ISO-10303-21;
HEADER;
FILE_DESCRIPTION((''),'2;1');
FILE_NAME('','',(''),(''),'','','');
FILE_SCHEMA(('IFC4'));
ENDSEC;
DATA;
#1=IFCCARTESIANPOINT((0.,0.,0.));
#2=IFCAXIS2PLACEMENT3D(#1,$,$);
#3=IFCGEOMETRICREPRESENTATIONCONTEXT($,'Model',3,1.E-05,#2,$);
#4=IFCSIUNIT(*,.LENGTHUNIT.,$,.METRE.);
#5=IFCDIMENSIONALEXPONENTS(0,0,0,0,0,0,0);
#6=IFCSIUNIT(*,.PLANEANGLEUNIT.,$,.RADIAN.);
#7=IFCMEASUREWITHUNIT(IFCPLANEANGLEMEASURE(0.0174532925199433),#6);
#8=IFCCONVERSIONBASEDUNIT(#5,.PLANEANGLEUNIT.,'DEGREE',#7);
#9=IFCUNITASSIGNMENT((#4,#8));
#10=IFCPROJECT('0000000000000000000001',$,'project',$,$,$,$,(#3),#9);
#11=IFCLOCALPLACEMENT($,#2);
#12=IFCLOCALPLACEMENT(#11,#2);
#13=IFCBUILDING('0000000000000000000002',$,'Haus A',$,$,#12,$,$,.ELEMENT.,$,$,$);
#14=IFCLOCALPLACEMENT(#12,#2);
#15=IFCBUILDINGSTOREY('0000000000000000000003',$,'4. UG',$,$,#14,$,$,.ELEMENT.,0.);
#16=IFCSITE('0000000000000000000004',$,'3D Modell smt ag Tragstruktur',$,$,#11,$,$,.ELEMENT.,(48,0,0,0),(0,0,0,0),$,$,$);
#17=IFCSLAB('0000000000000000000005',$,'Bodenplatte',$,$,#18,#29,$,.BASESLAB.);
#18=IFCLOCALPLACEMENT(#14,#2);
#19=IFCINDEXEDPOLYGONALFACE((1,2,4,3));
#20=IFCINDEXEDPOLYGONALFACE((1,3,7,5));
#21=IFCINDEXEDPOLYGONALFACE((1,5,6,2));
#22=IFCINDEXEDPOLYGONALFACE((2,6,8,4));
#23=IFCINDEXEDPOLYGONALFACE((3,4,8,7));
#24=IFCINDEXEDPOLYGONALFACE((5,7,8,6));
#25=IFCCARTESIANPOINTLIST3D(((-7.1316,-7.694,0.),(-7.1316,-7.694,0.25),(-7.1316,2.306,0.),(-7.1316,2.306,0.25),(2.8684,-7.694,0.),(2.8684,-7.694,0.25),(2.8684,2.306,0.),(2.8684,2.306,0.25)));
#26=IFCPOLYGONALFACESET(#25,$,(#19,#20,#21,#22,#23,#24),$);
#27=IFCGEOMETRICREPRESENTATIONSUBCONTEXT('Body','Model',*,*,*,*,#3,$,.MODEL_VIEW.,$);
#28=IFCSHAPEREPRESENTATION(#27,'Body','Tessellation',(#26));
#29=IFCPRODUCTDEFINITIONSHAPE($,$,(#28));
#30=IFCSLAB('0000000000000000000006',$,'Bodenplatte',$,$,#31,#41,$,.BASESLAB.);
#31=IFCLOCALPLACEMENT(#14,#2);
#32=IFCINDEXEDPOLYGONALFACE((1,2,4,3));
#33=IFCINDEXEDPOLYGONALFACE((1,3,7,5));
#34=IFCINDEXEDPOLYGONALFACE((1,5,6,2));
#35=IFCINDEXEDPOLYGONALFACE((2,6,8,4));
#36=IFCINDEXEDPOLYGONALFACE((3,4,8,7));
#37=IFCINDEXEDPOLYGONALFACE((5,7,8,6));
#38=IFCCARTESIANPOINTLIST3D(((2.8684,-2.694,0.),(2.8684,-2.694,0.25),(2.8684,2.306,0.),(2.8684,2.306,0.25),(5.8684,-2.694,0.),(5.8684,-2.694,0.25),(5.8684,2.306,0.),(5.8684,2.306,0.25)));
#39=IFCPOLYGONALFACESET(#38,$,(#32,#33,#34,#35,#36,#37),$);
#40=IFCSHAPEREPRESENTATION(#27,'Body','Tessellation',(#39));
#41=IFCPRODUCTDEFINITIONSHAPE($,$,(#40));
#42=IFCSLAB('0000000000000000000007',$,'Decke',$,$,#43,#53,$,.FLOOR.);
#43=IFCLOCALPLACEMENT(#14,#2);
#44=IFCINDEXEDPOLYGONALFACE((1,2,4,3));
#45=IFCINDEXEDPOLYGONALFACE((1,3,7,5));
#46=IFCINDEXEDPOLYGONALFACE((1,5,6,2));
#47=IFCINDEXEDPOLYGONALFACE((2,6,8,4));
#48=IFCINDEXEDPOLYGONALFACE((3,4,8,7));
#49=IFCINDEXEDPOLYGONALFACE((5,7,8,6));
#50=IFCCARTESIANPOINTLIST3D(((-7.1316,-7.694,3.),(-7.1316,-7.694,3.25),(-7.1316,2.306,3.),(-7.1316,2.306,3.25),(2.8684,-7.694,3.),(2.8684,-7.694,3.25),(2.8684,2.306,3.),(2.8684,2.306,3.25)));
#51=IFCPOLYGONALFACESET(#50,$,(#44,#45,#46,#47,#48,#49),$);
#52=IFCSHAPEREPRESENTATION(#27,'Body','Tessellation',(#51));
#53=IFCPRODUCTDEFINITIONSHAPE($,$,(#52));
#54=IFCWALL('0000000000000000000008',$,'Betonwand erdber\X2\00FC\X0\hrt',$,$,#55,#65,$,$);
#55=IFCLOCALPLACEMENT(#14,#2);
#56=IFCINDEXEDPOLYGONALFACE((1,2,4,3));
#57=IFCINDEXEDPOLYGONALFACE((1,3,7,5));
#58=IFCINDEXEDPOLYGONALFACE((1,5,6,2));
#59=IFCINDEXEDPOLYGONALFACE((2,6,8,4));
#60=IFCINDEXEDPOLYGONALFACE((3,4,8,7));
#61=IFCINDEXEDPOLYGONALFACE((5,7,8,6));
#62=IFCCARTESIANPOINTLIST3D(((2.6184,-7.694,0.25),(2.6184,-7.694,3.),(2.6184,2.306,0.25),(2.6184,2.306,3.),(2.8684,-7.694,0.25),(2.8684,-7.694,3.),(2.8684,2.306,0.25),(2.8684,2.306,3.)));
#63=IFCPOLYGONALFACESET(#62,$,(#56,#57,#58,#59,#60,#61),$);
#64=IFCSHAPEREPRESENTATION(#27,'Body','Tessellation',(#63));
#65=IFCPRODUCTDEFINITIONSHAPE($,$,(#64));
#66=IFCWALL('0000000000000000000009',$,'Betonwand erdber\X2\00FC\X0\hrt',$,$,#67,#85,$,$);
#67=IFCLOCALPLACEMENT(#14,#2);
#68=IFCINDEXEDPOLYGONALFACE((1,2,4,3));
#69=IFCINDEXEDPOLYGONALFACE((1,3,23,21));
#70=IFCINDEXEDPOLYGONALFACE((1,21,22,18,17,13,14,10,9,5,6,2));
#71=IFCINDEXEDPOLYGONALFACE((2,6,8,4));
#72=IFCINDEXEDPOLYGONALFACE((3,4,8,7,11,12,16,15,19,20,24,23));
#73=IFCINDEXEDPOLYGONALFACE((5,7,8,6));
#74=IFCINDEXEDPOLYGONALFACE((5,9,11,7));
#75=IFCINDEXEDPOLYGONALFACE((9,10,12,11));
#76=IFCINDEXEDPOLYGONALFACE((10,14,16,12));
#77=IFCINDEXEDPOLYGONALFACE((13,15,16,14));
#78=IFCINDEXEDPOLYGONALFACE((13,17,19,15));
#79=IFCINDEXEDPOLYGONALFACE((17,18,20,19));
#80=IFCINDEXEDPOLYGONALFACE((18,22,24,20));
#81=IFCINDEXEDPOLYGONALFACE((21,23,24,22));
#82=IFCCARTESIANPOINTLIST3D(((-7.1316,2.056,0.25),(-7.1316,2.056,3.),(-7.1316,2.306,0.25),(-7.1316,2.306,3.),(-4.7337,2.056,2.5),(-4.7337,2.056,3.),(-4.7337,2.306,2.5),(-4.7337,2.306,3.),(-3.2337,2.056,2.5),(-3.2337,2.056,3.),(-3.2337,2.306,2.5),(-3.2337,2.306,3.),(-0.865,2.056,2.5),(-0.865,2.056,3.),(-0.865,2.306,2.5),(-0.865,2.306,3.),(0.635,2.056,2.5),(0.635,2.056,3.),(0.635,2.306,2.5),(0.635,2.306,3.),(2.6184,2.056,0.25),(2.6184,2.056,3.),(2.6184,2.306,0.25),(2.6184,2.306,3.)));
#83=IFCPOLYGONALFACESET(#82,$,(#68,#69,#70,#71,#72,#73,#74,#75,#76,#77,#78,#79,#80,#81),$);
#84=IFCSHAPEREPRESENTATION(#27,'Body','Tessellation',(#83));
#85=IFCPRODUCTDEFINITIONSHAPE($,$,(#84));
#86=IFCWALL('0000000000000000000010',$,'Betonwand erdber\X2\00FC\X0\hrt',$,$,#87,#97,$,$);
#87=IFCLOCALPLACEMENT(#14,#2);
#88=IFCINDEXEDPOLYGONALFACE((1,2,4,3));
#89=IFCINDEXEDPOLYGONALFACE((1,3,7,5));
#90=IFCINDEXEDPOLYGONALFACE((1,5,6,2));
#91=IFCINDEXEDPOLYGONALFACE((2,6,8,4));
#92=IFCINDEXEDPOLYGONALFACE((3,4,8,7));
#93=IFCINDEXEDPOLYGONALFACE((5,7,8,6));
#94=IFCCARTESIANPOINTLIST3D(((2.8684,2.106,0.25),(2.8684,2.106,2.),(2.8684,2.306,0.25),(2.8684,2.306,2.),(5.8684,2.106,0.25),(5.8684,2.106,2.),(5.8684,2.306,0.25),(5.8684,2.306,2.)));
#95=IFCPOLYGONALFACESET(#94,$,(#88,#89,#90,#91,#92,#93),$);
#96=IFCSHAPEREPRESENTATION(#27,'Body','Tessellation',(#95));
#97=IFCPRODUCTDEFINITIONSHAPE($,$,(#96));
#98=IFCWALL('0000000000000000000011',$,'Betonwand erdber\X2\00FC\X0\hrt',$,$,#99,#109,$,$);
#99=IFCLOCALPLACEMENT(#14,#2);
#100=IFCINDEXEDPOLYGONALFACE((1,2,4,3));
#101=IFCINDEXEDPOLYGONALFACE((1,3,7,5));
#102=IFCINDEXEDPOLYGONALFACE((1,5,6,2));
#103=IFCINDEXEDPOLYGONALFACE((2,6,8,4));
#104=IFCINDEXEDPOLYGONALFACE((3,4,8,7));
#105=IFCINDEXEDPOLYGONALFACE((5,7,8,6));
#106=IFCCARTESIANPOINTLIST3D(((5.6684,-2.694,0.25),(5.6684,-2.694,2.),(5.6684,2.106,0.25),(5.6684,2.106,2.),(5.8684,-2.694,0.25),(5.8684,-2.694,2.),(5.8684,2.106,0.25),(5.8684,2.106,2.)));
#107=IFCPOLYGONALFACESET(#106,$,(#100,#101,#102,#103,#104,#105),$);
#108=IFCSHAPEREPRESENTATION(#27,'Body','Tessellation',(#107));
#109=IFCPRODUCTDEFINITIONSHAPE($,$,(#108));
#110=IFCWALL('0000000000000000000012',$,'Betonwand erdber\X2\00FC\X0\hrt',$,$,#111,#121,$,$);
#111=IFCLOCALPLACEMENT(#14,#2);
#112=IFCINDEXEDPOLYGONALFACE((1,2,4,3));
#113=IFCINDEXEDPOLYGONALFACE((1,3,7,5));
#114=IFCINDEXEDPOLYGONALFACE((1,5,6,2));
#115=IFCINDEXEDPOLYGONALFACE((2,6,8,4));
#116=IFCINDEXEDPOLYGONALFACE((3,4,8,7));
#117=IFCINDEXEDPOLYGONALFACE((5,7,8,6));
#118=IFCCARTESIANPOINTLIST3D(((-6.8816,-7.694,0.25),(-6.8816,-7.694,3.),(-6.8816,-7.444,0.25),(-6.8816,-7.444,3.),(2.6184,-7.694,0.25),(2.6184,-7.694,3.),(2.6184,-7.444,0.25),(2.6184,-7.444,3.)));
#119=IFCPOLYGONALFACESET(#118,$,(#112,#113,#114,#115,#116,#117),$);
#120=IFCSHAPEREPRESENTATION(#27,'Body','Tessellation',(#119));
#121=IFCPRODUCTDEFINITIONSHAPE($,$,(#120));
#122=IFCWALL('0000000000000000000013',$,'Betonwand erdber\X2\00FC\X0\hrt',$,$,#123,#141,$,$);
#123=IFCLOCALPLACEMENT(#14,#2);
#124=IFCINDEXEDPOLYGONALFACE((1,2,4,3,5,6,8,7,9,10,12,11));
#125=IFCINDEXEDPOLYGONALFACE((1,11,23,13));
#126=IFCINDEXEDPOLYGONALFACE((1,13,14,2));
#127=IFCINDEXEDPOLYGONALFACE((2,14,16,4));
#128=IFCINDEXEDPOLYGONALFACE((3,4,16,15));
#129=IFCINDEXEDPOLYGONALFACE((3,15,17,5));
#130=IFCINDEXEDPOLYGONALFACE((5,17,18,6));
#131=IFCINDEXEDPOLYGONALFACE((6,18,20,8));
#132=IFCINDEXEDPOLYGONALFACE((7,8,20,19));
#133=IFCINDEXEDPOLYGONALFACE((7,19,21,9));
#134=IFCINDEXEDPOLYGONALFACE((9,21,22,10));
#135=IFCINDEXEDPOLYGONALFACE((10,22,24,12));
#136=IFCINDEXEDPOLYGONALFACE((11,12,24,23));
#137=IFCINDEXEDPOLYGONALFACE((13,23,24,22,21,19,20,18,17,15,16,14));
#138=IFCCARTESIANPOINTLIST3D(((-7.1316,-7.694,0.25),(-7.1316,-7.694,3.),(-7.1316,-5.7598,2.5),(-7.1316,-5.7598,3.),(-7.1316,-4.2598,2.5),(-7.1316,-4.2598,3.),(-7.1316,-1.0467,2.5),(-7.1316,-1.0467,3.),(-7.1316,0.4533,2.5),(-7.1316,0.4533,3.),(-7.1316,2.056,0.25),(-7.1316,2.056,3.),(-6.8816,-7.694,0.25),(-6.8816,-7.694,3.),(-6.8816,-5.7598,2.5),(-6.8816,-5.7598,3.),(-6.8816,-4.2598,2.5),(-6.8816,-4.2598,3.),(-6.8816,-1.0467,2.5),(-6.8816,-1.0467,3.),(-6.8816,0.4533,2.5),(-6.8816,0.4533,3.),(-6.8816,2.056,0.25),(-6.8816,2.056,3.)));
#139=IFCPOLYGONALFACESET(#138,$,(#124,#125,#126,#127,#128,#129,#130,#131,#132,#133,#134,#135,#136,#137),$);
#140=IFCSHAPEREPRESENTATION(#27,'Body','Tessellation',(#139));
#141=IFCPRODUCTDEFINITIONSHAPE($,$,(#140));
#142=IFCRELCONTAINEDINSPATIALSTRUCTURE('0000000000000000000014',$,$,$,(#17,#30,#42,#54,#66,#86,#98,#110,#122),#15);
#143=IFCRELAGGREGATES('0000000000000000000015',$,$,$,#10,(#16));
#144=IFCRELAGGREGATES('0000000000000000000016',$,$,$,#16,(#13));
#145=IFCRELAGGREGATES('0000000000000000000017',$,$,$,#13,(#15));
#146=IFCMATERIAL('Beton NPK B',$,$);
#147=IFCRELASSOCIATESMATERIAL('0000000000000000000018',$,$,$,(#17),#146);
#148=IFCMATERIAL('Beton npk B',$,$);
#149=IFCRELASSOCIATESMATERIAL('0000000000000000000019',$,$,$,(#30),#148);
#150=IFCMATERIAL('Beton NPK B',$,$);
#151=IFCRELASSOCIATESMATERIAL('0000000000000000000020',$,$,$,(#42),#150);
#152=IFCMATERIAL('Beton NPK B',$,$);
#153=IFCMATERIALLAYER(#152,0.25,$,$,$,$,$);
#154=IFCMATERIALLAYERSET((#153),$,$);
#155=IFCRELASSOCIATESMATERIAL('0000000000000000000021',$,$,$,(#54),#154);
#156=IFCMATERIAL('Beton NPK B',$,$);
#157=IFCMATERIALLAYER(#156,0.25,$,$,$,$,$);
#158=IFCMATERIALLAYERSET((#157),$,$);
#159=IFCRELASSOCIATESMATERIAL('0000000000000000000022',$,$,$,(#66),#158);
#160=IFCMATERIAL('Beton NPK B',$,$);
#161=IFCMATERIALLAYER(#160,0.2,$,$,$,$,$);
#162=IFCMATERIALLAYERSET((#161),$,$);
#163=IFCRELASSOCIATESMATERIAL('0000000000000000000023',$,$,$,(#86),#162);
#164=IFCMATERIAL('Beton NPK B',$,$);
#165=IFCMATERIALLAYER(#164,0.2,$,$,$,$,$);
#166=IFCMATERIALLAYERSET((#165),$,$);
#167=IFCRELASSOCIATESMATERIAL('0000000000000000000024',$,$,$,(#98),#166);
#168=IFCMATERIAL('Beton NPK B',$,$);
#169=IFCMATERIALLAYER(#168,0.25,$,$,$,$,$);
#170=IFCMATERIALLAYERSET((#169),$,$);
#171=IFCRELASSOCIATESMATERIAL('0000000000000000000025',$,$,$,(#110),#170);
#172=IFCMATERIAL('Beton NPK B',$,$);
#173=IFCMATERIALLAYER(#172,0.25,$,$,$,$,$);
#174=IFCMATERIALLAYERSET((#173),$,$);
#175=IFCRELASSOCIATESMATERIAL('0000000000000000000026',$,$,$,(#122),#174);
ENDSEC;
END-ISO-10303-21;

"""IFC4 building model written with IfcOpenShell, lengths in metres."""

from ifc_helpers import new_model, entity, si_unit, converted_unit, frame, frame_2d, origin, origin_with_axes, place, context, subcontext, project, spatial, polyline, rectangle, outline, extrude, material, layer, layer_set, layer_usage, element, save


model = new_model("IFC4")

# Units and contexts
model_context = context("Model", 3, precision=1e-05, world=origin())
body_context = subcontext(model_context, "Body", "Model", "MODEL_VIEW")
ifc_project = project(units=[si_unit("LENGTHUNIT", "METRE"), converted_unit("PLANEANGLEUNIT", "DEGREE", entity("IfcPlaneAngleMeasure", 0.0174532925199433), si_unit("PLANEANGLEUNIT", "RADIAN"), dimensions=[0, 0, 0, 0, 0, 0, 0])], contexts=[model_context])

# Site, building, storey
site_placement = place(None, origin())
site = spatial("IfcSite", under=ifc_project, at=site_placement, Name="3D Modell smt ag Tragstruktur", CompositionType="ELEMENT", RefLatitude=(48, 0, 0, 0), RefLongitude=(0, 0, 0, 0))
building_placement = place(site_placement, origin())
building = spatial("IfcBuilding", under=site, at=building_placement, Name="Haus A", CompositionType="ELEMENT")
storey_placement = place(building_placement, origin())
storey = spatial("IfcBuildingStorey", under=building, at=storey_placement, Name="4. UG", CompositionType="ELEMENT", Elevation=0.0)

# Slabs
ifc_material_1 = material(Name="Beton NPK B")
slab_1_placement = place(storey_placement, frame((-7.1316, -7.694, 0.0)))
element("IfcSlab", 1, at=slab_1_placement, inside=storey, material=ifc_material_1, Name="Bodenplatte", PredefinedType="BASESLAB", context=body_context, shape_type="SweptSolid", body=[
    extrude(rectangle(XDim=10.0, YDim=10.0, at=frame_2d((5.0, -5.0), x_axis=(0.0, -1.0))), frame((0.0, 10.0, 0.0), z_axis=(0.0, 0.0, 1.0), x_axis=(1.0, 0.0, 0.0)), (0.0, 0.0, 1.0), 0.25),
])
ifc_material_2 = material(Name="Beton npk B")
slab_2_placement = place(storey_placement, frame((2.8684, -2.694, 0.0)))
element("IfcSlab", 2, at=slab_2_placement, inside=storey, material=ifc_material_2, Name="Bodenplatte", PredefinedType="BASESLAB", context=body_context, shape_type="SweptSolid", body=[
    extrude(rectangle(XDim=5.0, YDim=3.0, at=frame_2d((1.5, -2.5), x_axis=(0.0, -1.0))), frame((0.0, 5.0, 0.0), z_axis=(0.0, 0.0, 1.0), x_axis=(1.0, 0.0, 0.0)), (0.0, 0.0, 1.0), 0.25),
])
ifc_material_3 = material(Name="Beton NPK B")
slab_3_placement = place(storey_placement, frame((-7.1316, -7.694, 3.0)))
element("IfcSlab", 3, at=slab_3_placement, inside=storey, material=ifc_material_3, Name="Decke", PredefinedType="FLOOR", context=body_context, shape_type="SweptSolid", body=[
    extrude(rectangle(XDim=10.0, YDim=10.0, at=frame_2d((5.0, 5.0), x_axis=(1.0, 0.0))), origin_with_axes(), (0.0, 0.0, 1.0), 0.25),
])

# Wall
ifc_material_4 = material(Name="Beton NPK B")
ifc_layer_1 = layer(ifc_material_4, 0.25)
ifc_layer_set_1 = layer_set([ifc_layer_1])
ifc_layer_usage_1 = layer_usage(ifc_layer_set_1, "AXIS2", "POSITIVE", 0.0)
wall_1_placement = place(storey_placement, frame((2.8684, -7.694, 0.25), z_axis=(0.0, 0.0, 1.0), x_axis=(0.0, 1.0, 0.0)))
element("IfcWall", 4, at=wall_1_placement, inside=storey, material=ifc_layer_usage_1, Name="Betonwand erdberührt", context=body_context, shape_type="SweptSolid", body=[
    extrude(rectangle(XDim=10.0, YDim=0.25, at=frame_2d((5.0, 0.125), x_axis=(1.0, 0.0))), origin_with_axes(), (0.0, 0.0, 1.0), 2.75),
])

# Wall, openings
ifc_material_5 = material(Name="Beton NPK B")
ifc_layer_2 = layer(ifc_material_5, 0.25)
ifc_layer_set_2 = layer_set([ifc_layer_2])
ifc_layer_usage_2 = layer_usage(ifc_layer_set_2, "AXIS2", "POSITIVE", 0.0)
wall_2_placement = place(storey_placement, frame((2.6184, 2.306, 0.25), z_axis=(0.0, 0.0, 1.0), x_axis=(-1.0, 0.0, 0.0)))
wall_2 = element("IfcWall", 5, at=wall_2_placement, inside=storey, material=ifc_layer_usage_2, Name="Betonwand erdberührt", context=body_context, shape_type="SweptSolid", body=[
    extrude(rectangle(XDim=9.75, YDim=0.25, at=frame_2d((4.875, 0.125), x_axis=(1.0, 0.0))), origin_with_axes(), (0.0, 0.0, 1.0), 2.75),
])
opening_1_placement = place(wall_2_placement, frame((7.3522, 0.25, 2.25), z_axis=(0.0, -1.0, 0.0), x_axis=(0.0, 0.0, 1.0)))
element("IfcOpeningElement", 6, at=opening_1_placement, cuts=wall_2, ObjectType="Opening", context=body_context, shape_type="SweptSolid", body=[
    extrude(outline(polyline([(0.0, 1.5), (0.5, 1.5), (0.5, 0.0), (0.0, 0.0), (0.0, 1.5)])), origin_with_axes(), (0.0, 0.0, 1.0), 0.25),
])
opening_2_placement = place(wall_2_placement, frame((3.4834, 0.25, 2.25), z_axis=(0.0, -1.0, 0.0), x_axis=(0.0, 0.0, 1.0)))
element("IfcOpeningElement", 7, at=opening_2_placement, cuts=wall_2, ObjectType="Opening", context=body_context, shape_type="SweptSolid", body=[
    extrude(outline(polyline([(0.0, 1.5), (0.5, 1.5), (0.5, 0.0), (0.0, 0.0), (0.0, 1.5)])), origin_with_axes(), (0.0, 0.0, 1.0), 0.25),
])

# Walls
ifc_material_6 = material(Name="Beton NPK B")
ifc_layer_3 = layer(ifc_material_6, 0.2)
ifc_layer_set_3 = layer_set([ifc_layer_3])
ifc_layer_usage_3 = layer_usage(ifc_layer_set_3, "AXIS2", "POSITIVE", 0.0)
wall_3_placement = place(storey_placement, frame((5.8684, 2.306, 0.25), z_axis=(0.0, 0.0, 1.0), x_axis=(-1.0, 0.0, 0.0)))
element("IfcWall", 8, at=wall_3_placement, inside=storey, material=ifc_layer_usage_3, Name="Betonwand erdberührt", context=body_context, shape_type="SweptSolid", body=[
    extrude(rectangle(XDim=3.0, YDim=0.2, at=frame_2d((1.5, 0.1), x_axis=(1.0, 0.0))), origin_with_axes(), (0.0, 0.0, 1.0), 1.75),
])
ifc_material_7 = material(Name="Beton NPK B")
ifc_layer_4 = layer(ifc_material_7, 0.2)
ifc_layer_set_4 = layer_set([ifc_layer_4])
ifc_layer_usage_4 = layer_usage(ifc_layer_set_4, "AXIS2", "POSITIVE", 0.0)
wall_4_placement = place(storey_placement, frame((5.8684, -2.694, 0.25), z_axis=(0.0, 0.0, 1.0), x_axis=(0.0, 1.0, 0.0)))
element("IfcWall", 9, at=wall_4_placement, inside=storey, material=ifc_layer_usage_4, Name="Betonwand erdberührt", context=body_context, shape_type="SweptSolid", body=[
    extrude(rectangle(XDim=4.8, YDim=0.2, at=frame_2d((2.4, 0.1), x_axis=(1.0, 0.0))), origin_with_axes(), (0.0, 0.0, 1.0), 1.75),
])
ifc_material_8 = material(Name="Beton NPK B")
ifc_layer_5 = layer(ifc_material_8, 0.25)
ifc_layer_set_5 = layer_set([ifc_layer_5])
ifc_layer_usage_5 = layer_usage(ifc_layer_set_5, "AXIS2", "POSITIVE", 0.0)
wall_5_placement = place(storey_placement, frame((-6.8816, -7.694, 0.25), z_axis=(0.0, 0.0, 1.0), x_axis=(1.0, 0.0, 0.0)))
element("IfcWall", 10, at=wall_5_placement, inside=storey, material=ifc_layer_usage_5, Name="Betonwand erdberührt", context=body_context, shape_type="SweptSolid", body=[
    extrude(rectangle(XDim=9.5, YDim=0.25, at=frame_2d((4.75, 0.125), x_axis=(1.0, 0.0))), origin_with_axes(), (0.0, 0.0, 1.0), 2.75),
])

# Wall, openings
ifc_material_9 = material(Name="Beton NPK B")
ifc_layer_6 = layer(ifc_material_9, 0.25)
ifc_layer_set_6 = layer_set([ifc_layer_6])
ifc_layer_usage_6 = layer_usage(ifc_layer_set_6, "AXIS2", "POSITIVE", 0.0)
wall_6_placement = place(storey_placement, frame((-7.1316, 2.056, 0.25), z_axis=(0.0, 0.0, 1.0), x_axis=(0.0, -1.0, 0.0)))
wall_6 = element("IfcWall", 11, at=wall_6_placement, inside=storey, material=ifc_layer_usage_6, Name="Betonwand erdberührt", context=body_context, shape_type="SweptSolid", body=[
    extrude(rectangle(XDim=9.75, YDim=0.25, at=frame_2d((4.875, 0.125), x_axis=(1.0, 0.0))), origin_with_axes(), (0.0, 0.0, 1.0), 2.75),
])
opening_3_placement = place(wall_6_placement, frame((6.3158, 0.0, 2.25), z_axis=(0.0, 1.0, 0.0), x_axis=(0.0, 0.0, 1.0)))
element("IfcOpeningElement", 12, at=opening_3_placement, cuts=wall_6, ObjectType="Opening", context=body_context, shape_type="SweptSolid", body=[
    extrude(outline(polyline([(0.0, 1.5), (0.5, 1.5), (0.5, 0.0), (0.0, 0.0), (0.0, 1.5)])), origin_with_axes(), (0.0, 0.0, 1.0), 0.25),
])
opening_4_placement = place(wall_6_placement, frame((1.6027, 0.0, 2.25), z_axis=(0.0, 1.0, 0.0), x_axis=(0.0, 0.0, 1.0)))
element("IfcOpeningElement", 13, at=opening_4_placement, cuts=wall_6, ObjectType="Opening", context=body_context, shape_type="SweptSolid", body=[
    extrude(outline(polyline([(0.0, 1.5), (0.5, 1.5), (0.5, 0.0), (0.0, 0.0), (0.0, 1.5)])), origin_with_axes(), (0.0, 0.0, 1.0), 0.25),
])

save(model, "model.ifc")
